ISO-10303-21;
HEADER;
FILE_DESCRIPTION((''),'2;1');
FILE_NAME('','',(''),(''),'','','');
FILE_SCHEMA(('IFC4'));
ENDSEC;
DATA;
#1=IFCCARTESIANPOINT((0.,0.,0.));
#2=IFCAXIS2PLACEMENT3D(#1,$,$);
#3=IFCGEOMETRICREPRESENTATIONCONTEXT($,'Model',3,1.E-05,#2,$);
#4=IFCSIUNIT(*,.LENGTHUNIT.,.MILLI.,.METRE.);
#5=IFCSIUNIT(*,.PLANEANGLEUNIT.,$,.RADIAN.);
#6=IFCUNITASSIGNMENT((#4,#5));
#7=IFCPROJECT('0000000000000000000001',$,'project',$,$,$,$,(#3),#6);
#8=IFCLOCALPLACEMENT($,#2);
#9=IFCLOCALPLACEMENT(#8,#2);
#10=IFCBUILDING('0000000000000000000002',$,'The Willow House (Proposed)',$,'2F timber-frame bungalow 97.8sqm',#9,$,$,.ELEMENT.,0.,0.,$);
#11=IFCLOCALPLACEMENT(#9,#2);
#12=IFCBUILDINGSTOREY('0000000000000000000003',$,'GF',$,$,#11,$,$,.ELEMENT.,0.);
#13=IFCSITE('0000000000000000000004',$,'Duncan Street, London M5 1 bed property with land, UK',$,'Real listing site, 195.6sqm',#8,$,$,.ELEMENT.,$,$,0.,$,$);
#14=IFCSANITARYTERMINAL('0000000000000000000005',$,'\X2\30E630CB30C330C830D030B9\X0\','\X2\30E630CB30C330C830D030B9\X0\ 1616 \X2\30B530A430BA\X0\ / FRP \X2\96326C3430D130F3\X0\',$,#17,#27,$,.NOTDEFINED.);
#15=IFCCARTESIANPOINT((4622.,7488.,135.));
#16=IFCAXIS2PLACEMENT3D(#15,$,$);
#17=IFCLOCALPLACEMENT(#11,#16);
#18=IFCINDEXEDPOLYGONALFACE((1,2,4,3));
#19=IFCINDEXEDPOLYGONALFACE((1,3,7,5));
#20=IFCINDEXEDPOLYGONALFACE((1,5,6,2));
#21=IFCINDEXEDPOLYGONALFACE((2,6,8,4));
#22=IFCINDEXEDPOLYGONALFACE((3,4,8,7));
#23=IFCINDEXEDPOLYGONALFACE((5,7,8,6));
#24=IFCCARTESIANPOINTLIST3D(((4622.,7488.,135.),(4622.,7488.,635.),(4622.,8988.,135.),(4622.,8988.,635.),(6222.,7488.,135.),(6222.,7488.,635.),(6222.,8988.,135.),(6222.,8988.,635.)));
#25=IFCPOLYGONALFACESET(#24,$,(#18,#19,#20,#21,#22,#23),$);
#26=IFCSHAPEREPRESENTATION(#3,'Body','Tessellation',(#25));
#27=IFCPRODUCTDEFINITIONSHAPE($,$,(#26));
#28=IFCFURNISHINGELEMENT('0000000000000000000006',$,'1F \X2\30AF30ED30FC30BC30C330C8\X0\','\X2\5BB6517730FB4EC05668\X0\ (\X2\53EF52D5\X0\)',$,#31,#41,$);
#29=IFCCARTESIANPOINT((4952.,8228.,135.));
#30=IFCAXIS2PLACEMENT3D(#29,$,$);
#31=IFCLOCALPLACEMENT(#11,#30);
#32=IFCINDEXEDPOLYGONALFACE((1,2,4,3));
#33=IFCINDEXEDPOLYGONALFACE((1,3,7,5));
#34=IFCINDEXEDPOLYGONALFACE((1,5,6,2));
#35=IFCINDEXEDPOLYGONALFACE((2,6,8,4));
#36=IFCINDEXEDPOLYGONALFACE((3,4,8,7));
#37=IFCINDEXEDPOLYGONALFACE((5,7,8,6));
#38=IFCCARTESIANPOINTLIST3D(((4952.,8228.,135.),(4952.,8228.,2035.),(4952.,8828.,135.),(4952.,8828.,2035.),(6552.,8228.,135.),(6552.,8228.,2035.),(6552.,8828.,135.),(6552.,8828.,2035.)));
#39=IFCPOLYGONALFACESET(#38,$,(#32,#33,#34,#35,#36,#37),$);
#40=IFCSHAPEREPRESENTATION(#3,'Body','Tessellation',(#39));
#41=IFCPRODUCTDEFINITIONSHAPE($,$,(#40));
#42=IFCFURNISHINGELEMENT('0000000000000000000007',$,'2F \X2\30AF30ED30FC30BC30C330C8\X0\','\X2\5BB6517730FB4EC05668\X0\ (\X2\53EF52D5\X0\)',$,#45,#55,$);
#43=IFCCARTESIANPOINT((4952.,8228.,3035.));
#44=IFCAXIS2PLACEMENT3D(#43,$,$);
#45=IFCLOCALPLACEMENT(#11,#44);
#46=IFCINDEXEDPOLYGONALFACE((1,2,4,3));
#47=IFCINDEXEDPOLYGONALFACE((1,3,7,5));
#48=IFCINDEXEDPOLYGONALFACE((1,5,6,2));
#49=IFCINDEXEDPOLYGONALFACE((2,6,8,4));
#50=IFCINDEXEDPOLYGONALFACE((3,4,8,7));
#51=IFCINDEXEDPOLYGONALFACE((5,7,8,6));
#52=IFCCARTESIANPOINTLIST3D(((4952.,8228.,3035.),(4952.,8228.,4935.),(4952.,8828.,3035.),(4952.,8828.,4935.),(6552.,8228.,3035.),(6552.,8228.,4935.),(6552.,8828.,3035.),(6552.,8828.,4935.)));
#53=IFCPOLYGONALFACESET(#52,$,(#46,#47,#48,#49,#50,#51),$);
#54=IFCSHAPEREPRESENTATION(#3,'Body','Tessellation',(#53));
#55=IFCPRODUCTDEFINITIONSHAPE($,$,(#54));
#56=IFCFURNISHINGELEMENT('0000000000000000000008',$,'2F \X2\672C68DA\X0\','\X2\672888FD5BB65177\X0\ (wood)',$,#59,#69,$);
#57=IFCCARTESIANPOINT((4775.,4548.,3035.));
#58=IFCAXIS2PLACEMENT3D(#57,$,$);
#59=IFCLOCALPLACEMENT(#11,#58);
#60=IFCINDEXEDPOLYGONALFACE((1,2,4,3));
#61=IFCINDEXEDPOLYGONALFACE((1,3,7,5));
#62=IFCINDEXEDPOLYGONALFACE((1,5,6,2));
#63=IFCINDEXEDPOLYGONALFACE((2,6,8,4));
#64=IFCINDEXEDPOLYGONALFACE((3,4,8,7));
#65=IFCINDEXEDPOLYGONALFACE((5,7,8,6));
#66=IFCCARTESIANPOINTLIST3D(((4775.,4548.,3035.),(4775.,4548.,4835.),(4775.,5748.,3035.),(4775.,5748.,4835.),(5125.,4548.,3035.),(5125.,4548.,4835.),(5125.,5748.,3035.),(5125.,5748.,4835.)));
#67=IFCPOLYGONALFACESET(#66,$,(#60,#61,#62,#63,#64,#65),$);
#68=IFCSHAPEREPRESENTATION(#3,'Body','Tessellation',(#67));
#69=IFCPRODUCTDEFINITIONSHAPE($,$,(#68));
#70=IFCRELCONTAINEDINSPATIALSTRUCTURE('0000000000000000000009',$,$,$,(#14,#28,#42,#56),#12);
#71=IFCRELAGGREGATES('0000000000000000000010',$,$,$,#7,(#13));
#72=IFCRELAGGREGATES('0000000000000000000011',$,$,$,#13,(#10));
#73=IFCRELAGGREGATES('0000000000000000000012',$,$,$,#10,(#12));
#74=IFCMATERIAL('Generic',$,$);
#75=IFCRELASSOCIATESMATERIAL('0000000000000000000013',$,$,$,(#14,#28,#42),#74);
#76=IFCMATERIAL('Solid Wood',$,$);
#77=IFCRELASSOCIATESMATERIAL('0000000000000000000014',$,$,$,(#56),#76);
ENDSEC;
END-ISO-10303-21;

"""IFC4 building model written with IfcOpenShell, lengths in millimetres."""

from ifc_helpers import new_model, si_unit, frame, frame_2d, origin, place, context, project, spatial, rectangle, extrude, material, element, save


model = new_model("IFC4")

# Units and contexts
model_context = context("Model", 3, precision=1e-05, world=origin())
ifc_project = project(units=[si_unit("LENGTHUNIT", "METRE", prefix="MILLI"), si_unit("PLANEANGLEUNIT", "RADIAN")], contexts=[model_context])

# Site, building, storey
site_placement = place(None, origin())
site = spatial("IfcSite", under=ifc_project, at=site_placement, Name="Duncan Street, London M5 1 bed property with land, UK", ObjectType="Real listing site, 195.6sqm", CompositionType="ELEMENT", RefElevation=0.0)
building_placement = place(site_placement, origin())
building = spatial("IfcBuilding", under=site, at=building_placement, Name="The Willow House (Proposed)", ObjectType="2F timber-frame bungalow 97.8sqm", CompositionType="ELEMENT", ElevationOfRefHeight=0.0, ElevationOfTerrain=0.0)
storey_placement = place(building_placement, origin())
storey = spatial("IfcBuildingStorey", under=building, at=storey_placement, Name="GF", CompositionType="ELEMENT", Elevation=0.0)

# Shared definitions
ifc_material_1 = material(Name="Solid Wood")

# Shared definitions
ifc_material_2 = material(Name="Generic")

# Sanitary terminal
sanitary_terminal_placement = place(storey_placement, frame((4622.0, 7488.0, 135.0)))
element("IfcSanitaryTerminal", 1, at=sanitary_terminal_placement, inside=storey, material=ifc_material_2, Name="ユニットバス", Description="ユニットバス 1616 サイズ / FRP 防水パン", PredefinedType="NOTDEFINED", context=model_context, shape_type="SweptSolid", body=[
    extrude(rectangle(XDim=1600.0, YDim=1500.0, at=frame_2d((800.0, 750.0))), frame((4622.0, 7488.0, 135.0)), (0.0, 0.0, 1.0), 500.0),
])

# Furnishing elements
furnishing_1_placement = place(storey_placement, frame((4952.0, 8228.0, 135.0)))
element("IfcFurnishingElement", 2, at=furnishing_1_placement, inside=storey, material=ifc_material_2, Name="1F クローゼット", Description="家具・什器 (可動)", context=model_context, shape_type="SweptSolid", body=[
    extrude(rectangle(XDim=1600.0, YDim=600.0, at=frame_2d((800.0, 300.0))), frame((4952.0, 8228.0, 135.0)), (0.0, 0.0, 1.0), 1900.0),
])
furnishing_2_placement = place(storey_placement, frame((4952.0, 8228.0, 3035.0)))
element("IfcFurnishingElement", 3, at=furnishing_2_placement, inside=storey, material=ifc_material_2, Name="2F クローゼット", Description="家具・什器 (可動)", context=model_context, shape_type="SweptSolid", body=[
    extrude(rectangle(XDim=1600.0, YDim=600.0, at=frame_2d((800.0, 300.0))), frame((4952.0, 8228.0, 3035.0)), (0.0, 0.0, 1.0), 1900.0),
])
furnishing_3_placement = place(storey_placement, frame((4775.0, 4548.0, 3035.0)))
element("IfcFurnishingElement", 4, at=furnishing_3_placement, inside=storey, material=ifc_material_1, Name="2F 本棚", Description="木製家具 (wood)", context=model_context, shape_type="SweptSolid", body=[
    extrude(rectangle(XDim=350.0, YDim=1200.0, at=frame_2d((175.0, 600.0))), frame((4775.0, 4548.0, 3035.0)), (0.0, 0.0, 1.0), 1800.0),
])

save(model, "model.ifc")
